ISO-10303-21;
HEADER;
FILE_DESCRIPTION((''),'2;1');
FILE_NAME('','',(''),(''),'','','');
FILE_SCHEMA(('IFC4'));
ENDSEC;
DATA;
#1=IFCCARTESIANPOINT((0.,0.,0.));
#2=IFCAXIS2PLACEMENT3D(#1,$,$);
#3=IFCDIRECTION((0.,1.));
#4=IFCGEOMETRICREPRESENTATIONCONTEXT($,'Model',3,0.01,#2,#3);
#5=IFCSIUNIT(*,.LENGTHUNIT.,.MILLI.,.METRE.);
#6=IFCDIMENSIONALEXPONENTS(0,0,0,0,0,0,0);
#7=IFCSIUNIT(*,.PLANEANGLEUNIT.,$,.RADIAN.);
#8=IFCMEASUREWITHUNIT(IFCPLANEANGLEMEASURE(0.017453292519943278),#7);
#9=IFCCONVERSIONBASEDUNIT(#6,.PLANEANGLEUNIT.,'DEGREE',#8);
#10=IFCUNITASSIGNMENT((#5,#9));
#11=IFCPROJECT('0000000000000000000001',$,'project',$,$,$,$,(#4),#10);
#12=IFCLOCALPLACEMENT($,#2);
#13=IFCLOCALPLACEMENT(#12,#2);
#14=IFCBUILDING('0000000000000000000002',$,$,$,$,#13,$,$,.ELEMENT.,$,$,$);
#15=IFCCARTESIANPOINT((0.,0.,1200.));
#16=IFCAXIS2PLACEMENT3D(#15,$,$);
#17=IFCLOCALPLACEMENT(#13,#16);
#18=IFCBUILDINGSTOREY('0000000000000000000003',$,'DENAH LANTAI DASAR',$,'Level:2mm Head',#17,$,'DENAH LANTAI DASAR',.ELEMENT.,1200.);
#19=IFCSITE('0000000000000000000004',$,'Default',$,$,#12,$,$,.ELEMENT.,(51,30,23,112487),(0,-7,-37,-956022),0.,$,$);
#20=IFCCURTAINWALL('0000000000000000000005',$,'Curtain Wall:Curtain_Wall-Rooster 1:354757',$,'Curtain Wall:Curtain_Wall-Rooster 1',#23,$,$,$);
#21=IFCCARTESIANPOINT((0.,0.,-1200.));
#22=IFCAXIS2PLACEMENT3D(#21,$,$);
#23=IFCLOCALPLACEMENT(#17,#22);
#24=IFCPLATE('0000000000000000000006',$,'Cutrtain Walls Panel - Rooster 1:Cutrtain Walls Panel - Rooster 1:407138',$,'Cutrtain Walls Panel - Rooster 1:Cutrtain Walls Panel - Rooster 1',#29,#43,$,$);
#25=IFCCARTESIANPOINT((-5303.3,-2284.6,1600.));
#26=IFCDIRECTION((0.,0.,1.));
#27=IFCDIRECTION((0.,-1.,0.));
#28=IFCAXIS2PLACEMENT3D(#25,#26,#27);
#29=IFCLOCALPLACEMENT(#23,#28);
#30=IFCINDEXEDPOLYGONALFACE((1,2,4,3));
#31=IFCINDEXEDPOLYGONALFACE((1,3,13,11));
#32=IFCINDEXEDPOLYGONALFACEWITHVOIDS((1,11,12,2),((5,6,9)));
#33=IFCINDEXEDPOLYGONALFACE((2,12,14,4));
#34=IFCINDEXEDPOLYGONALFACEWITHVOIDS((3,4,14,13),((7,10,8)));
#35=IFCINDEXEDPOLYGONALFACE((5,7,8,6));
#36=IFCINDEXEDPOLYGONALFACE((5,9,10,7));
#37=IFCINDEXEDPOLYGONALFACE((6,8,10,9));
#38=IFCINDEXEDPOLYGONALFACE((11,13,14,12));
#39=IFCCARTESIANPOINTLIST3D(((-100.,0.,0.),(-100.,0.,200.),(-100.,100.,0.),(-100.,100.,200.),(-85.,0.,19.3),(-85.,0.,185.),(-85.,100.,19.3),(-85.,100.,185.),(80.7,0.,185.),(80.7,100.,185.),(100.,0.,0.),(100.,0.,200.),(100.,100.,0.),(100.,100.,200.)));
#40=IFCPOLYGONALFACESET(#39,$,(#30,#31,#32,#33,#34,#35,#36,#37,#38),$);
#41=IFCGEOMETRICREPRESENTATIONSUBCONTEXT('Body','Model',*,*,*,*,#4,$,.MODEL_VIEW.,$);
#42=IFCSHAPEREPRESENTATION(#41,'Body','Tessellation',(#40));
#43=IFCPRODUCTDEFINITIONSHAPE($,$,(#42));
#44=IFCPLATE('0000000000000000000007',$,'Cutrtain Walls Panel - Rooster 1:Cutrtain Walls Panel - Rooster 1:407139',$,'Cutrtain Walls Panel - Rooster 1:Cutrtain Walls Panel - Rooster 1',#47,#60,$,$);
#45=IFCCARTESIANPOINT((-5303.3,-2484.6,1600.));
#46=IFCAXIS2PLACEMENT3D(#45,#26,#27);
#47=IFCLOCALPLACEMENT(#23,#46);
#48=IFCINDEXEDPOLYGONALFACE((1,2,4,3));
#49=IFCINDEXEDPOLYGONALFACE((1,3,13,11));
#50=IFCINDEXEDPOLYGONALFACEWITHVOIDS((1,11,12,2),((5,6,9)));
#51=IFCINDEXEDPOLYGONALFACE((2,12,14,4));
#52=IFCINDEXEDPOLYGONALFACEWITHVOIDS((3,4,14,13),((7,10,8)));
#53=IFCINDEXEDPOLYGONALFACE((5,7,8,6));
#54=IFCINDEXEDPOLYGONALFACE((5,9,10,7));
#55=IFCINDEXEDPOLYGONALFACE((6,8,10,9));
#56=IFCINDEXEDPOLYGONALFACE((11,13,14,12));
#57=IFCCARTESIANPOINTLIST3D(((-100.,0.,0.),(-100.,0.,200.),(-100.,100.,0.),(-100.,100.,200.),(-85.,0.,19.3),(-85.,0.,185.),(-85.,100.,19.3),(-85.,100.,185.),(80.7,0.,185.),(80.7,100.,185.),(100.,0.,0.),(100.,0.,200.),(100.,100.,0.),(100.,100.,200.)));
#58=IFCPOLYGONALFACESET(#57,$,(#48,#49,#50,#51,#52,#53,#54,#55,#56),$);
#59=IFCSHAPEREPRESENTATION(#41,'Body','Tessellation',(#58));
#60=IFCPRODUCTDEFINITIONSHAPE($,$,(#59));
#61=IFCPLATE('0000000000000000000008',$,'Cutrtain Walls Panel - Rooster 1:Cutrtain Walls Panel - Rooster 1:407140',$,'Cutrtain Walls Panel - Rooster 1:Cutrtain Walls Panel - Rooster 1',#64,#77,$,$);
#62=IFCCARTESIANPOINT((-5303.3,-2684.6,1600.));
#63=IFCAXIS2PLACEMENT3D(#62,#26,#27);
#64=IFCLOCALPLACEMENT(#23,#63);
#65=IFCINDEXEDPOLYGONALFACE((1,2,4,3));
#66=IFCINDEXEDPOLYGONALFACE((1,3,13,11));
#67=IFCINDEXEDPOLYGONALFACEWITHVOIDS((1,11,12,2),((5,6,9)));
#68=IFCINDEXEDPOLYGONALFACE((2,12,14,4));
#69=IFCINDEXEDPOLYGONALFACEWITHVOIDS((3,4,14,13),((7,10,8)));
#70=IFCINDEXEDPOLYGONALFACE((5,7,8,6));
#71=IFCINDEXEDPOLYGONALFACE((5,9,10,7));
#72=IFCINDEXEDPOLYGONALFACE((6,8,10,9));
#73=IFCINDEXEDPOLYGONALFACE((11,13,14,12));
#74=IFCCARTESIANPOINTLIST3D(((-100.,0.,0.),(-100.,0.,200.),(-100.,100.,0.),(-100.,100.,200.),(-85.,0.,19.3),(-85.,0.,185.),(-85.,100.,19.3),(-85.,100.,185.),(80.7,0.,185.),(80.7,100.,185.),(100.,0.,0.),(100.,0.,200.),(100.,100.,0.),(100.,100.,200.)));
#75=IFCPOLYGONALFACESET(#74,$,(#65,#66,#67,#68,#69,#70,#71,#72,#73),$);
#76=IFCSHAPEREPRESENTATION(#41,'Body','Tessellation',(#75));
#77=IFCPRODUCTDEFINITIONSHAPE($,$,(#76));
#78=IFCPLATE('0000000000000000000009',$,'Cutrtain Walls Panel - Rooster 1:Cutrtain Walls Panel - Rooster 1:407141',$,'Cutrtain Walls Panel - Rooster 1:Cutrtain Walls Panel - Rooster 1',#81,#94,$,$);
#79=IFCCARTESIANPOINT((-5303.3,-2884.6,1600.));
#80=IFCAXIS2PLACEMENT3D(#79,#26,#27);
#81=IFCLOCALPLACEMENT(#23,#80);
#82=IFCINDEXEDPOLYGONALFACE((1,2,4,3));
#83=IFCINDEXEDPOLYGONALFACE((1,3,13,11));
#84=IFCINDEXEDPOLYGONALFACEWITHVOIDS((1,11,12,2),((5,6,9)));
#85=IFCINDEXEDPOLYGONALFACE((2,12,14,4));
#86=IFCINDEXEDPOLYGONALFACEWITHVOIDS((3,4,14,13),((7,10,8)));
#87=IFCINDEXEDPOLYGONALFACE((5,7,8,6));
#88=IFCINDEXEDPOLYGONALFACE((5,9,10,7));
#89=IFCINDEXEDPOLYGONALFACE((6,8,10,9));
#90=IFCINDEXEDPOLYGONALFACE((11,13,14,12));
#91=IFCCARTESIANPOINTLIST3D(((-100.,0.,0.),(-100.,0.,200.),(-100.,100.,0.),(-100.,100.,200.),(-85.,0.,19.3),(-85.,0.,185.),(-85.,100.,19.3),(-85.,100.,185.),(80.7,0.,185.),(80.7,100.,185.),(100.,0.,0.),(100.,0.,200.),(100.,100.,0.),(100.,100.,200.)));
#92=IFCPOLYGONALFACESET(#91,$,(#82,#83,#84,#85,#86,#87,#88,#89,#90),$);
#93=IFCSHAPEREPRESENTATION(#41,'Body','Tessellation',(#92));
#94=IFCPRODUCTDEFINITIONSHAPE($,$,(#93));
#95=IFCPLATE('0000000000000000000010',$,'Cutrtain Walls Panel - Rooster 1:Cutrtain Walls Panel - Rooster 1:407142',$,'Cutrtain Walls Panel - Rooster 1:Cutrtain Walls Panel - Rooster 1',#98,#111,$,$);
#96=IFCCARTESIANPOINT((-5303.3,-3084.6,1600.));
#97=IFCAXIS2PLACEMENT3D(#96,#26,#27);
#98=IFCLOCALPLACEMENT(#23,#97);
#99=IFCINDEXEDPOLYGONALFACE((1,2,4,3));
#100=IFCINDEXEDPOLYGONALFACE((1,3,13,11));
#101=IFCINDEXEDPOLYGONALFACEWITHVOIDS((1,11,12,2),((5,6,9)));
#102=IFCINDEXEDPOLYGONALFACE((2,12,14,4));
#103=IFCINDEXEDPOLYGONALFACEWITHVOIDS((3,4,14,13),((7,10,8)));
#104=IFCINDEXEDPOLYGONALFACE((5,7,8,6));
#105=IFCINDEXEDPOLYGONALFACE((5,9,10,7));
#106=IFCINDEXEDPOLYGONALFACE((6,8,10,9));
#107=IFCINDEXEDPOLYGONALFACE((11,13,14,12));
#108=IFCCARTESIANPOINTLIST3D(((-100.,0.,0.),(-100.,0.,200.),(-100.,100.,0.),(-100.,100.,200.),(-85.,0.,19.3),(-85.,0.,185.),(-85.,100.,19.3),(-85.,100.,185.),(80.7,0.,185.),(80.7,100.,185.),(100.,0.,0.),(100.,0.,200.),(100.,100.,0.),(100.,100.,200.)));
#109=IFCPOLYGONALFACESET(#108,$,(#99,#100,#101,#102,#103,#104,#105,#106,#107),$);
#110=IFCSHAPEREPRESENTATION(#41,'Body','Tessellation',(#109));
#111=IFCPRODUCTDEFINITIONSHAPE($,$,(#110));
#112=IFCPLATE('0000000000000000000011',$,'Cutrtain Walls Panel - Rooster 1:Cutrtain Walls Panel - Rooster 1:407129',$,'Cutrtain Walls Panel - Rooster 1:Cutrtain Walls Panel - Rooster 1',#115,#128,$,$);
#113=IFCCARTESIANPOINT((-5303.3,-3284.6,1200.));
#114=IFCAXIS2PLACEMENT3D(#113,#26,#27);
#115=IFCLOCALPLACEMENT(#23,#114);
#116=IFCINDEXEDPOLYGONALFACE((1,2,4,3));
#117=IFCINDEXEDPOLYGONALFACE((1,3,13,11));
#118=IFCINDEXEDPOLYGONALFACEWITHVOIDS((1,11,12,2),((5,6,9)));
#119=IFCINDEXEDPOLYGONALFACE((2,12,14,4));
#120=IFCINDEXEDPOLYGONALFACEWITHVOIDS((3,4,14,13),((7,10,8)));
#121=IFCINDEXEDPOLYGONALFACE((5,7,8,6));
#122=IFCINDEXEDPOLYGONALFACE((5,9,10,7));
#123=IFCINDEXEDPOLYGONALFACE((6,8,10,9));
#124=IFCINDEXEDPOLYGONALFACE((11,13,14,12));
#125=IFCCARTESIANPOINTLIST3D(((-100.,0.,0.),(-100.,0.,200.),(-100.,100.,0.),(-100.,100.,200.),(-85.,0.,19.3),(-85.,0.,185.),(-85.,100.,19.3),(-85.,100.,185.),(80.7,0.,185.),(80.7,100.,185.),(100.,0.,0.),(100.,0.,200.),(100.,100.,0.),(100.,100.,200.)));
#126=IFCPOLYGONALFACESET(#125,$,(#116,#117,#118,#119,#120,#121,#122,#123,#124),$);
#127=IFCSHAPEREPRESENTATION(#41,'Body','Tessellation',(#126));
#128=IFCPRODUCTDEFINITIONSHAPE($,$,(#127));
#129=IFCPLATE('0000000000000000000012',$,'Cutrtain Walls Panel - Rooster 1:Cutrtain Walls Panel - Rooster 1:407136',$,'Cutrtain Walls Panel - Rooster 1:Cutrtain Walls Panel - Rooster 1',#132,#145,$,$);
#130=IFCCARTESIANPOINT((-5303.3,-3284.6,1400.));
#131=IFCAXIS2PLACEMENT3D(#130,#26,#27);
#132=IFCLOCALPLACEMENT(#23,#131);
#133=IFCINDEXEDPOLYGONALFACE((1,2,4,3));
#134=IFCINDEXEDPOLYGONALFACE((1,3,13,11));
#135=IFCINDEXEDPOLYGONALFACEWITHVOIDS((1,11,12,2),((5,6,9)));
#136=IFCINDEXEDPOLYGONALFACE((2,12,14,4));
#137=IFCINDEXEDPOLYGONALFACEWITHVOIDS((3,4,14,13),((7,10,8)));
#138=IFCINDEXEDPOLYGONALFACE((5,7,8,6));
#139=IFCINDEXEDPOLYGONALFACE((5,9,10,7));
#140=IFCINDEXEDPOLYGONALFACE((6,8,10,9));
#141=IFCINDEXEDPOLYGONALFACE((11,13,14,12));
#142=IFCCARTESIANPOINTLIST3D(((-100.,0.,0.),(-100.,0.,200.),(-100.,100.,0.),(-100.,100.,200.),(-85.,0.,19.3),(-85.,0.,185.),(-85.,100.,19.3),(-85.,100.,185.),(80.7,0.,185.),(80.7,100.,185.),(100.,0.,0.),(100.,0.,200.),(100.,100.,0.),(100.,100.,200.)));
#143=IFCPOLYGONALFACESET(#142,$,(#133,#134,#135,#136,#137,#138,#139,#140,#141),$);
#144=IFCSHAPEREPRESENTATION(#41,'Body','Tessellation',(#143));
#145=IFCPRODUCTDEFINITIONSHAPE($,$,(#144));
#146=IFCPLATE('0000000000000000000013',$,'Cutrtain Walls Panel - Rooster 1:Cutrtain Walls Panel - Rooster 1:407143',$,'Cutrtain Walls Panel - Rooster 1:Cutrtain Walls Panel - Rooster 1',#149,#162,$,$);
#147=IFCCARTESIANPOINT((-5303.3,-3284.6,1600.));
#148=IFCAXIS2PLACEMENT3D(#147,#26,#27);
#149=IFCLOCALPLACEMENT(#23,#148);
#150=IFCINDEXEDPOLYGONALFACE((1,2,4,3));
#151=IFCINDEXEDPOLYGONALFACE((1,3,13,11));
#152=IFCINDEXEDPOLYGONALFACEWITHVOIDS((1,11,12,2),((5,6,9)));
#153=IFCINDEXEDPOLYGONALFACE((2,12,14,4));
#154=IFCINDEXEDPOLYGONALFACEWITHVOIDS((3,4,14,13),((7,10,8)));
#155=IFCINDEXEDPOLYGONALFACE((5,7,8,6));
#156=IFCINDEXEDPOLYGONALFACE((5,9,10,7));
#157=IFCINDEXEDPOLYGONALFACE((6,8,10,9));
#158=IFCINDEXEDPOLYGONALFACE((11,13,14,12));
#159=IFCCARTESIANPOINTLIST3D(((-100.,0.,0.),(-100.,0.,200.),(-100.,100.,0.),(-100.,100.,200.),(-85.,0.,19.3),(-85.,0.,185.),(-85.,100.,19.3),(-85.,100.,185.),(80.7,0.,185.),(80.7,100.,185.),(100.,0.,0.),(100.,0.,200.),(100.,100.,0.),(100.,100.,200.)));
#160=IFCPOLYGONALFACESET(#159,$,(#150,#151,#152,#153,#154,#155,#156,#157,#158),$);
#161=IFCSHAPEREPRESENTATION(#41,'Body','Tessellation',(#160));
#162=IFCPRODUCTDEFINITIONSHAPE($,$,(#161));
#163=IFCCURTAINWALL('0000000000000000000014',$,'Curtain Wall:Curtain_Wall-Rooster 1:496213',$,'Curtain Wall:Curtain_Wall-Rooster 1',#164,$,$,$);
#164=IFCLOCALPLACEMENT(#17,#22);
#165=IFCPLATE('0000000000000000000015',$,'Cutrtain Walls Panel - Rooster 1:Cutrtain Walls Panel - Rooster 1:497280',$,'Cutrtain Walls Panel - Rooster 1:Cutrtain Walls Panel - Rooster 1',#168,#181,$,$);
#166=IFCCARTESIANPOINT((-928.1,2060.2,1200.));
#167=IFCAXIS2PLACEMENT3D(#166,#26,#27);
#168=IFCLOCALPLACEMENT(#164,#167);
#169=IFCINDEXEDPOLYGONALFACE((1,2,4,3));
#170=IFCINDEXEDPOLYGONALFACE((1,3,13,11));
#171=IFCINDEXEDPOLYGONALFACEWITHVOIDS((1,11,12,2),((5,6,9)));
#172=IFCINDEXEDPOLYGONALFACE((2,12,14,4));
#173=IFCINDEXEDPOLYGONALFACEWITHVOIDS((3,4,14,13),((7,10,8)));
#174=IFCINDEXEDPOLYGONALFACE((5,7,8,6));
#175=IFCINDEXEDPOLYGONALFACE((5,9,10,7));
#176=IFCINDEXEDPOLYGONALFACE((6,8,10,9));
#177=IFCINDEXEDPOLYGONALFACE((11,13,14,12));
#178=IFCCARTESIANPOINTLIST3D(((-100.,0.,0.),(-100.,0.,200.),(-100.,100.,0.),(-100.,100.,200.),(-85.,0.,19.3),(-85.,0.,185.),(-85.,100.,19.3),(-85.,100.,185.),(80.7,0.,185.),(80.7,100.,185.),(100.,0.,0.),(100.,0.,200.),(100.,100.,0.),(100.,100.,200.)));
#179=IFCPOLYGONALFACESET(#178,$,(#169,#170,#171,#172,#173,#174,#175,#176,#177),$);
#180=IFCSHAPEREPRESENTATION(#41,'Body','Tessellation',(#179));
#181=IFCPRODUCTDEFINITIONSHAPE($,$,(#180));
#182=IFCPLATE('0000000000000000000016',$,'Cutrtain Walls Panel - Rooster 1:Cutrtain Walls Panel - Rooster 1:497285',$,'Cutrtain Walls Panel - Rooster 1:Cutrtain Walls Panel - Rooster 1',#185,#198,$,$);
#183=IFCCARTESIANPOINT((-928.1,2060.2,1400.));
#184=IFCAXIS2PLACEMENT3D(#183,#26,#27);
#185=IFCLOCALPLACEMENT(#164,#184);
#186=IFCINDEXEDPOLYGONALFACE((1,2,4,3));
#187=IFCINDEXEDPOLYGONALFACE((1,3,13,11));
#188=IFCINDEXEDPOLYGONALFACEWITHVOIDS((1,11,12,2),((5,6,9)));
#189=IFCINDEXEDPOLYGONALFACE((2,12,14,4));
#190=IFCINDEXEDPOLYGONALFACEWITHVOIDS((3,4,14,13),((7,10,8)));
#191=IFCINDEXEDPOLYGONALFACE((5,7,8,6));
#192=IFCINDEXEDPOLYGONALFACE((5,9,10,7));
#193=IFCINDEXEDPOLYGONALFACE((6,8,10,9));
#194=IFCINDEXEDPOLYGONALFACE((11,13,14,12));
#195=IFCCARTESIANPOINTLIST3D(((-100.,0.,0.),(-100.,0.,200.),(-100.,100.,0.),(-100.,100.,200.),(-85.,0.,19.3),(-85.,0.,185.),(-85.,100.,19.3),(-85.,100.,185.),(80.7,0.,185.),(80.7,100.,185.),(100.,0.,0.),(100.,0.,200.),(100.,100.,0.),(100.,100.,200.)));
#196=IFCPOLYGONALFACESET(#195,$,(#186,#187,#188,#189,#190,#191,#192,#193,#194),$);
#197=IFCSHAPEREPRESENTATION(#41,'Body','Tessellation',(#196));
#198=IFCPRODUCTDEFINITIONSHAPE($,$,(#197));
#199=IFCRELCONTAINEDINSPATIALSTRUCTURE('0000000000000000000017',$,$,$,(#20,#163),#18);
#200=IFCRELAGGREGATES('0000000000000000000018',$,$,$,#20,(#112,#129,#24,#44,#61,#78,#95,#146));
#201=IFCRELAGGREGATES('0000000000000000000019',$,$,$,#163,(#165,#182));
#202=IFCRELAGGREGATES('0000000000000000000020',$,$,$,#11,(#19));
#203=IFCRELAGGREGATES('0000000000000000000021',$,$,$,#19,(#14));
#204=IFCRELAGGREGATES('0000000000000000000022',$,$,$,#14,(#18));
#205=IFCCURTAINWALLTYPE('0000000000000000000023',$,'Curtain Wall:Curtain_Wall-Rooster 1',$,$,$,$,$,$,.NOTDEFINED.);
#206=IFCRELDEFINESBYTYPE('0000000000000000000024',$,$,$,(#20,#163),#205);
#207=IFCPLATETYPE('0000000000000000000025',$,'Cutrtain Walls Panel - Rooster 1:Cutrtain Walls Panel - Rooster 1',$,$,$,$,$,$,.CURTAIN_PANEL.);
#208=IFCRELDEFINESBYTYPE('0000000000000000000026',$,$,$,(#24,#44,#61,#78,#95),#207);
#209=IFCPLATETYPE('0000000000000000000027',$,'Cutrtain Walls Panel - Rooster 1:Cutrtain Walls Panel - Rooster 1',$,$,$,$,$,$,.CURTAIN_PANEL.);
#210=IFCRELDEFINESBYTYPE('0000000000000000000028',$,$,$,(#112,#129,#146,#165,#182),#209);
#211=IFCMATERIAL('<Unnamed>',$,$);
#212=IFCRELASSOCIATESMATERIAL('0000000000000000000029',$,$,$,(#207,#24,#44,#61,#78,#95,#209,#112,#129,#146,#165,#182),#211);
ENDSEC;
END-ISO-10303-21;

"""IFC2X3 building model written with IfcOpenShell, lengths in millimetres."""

from ifc_helpers import new_model, entity, si_unit, converted_unit, direction, frame, origin, place, context, subcontext, project, spatial, polyline, outline, extrude, source, transform, mapped, material, type_object, type_shapes, element, aggregate, save


model = new_model("IFC2X3")

# Units and contexts
model_context = context("Model", 3, precision=0.01, world=origin(), true_north=direction((0.0, 1.0)))
body_context = subcontext(model_context, "Body", "Model", "MODEL_VIEW")
ifc_project = project(units=[si_unit("LENGTHUNIT", "METRE", prefix="MILLI"), converted_unit("PLANEANGLEUNIT", "DEGREE", entity("IfcPlaneAngleMeasure", 0.017453292519943278), si_unit("PLANEANGLEUNIT", "RADIAN"), dimensions=[0, 0, 0, 0, 0, 0, 0])], contexts=[model_context])

# Site, building, storey
site_placement = place(None, origin())
site = spatial("IfcSite", under=ifc_project, at=site_placement, Name="Default", CompositionType="ELEMENT", RefLatitude=(51, 30, 23, 112487), RefLongitude=(0, -7, -37, -956022), RefElevation=0.0)
building_placement = place(site_placement, origin())
building = spatial("IfcBuilding", under=site, at=building_placement, CompositionType="ELEMENT")
storey_placement = place(building_placement, frame((0.0, 0.0, 1200.0)))
storey = spatial("IfcBuildingStorey", under=building, at=storey_placement, Name="DENAH LANTAI DASAR", ObjectType="Level:2mm Head", LongName="DENAH LANTAI DASAR", CompositionType="ELEMENT", Elevation=1200.0)

# Curtain walls, plates
curtain_wall_type = type_object("IfcCurtainWallType", Name="Curtain Wall:Curtain_Wall-Rooster 1", PredefinedType="NOTDEFINED")
curtain_wall_1_placement = place(storey_placement, frame((0.0, 0.0, -1200.0)))
curtain_wall_1 = element("IfcCurtainWall", 1, at=curtain_wall_1_placement, inside=storey, type_object=curtain_wall_type, Name="Curtain Wall:Curtain_Wall-Rooster 1:354757", ObjectType="Curtain Wall:Curtain_Wall-Rooster 1")
ifc_material_1 = material(Name="<Unnamed>")
plate_type_1 = type_object("IfcPlateType", Name="Cutrtain Walls Panel - Rooster 1:Cutrtain Walls Panel - Rooster 1", PredefinedType="CURTAIN_PANEL", material=ifc_material_1)
shared_shape_1 = source(origin(), body_context, "Body", "SweptSolid", [
    extrude(outline(polyline([(-100.0, -100.0), (100.0, -100.0), (100.0, 100.0), (-100.0, 100.0), (-100.0, -100.0)]), holes=[polyline([(80.7, 85.0), (-85.0, -80.7), (-85.0, 85.0), (80.7, 85.0)])]), frame((0.0, 0.0, 100.0), z_axis=(0.0, 1.0, 0.0), x_axis=(0.0, 0.0, -1.0)), (0.0, 0.0, 1.0), 100.0),
])
type_shapes(plate_type_1, [shared_shape_1])
plate_1_placement = place(curtain_wall_1_placement, frame((-5303.3, -2284.6, 1600.0), z_axis=(0.0, 0.0, 1.0), x_axis=(0.0, -1.0, 0.0)))
plate_1 = element("IfcPlate", 2, at=plate_1_placement, type_object=plate_type_1, material=ifc_material_1, Name="Cutrtain Walls Panel - Rooster 1:Cutrtain Walls Panel - Rooster 1:407138", ObjectType="Cutrtain Walls Panel - Rooster 1:Cutrtain Walls Panel - Rooster 1", context=body_context, shape_type="MappedRepresentation", body=[
    mapped(shared_shape_1, transform((0.0, 0.0, 0.0), scale=1.0)),
])
plate_2_placement = place(curtain_wall_1_placement, frame((-5303.3, -2484.6, 1600.0), z_axis=(0.0, 0.0, 1.0), x_axis=(0.0, -1.0, 0.0)))
plate_2 = element("IfcPlate", 3, at=plate_2_placement, type_object=plate_type_1, material=ifc_material_1, Name="Cutrtain Walls Panel - Rooster 1:Cutrtain Walls Panel - Rooster 1:407139", ObjectType="Cutrtain Walls Panel - Rooster 1:Cutrtain Walls Panel - Rooster 1", context=body_context, shape_type="MappedRepresentation", body=[
    mapped(shared_shape_1, transform((0.0, 0.0, 0.0), scale=1.0)),
])
plate_3_placement = place(curtain_wall_1_placement, frame((-5303.3, -2684.6, 1600.0), z_axis=(0.0, 0.0, 1.0), x_axis=(0.0, -1.0, 0.0)))
plate_3 = element("IfcPlate", 4, at=plate_3_placement, type_object=plate_type_1, material=ifc_material_1, Name="Cutrtain Walls Panel - Rooster 1:Cutrtain Walls Panel - Rooster 1:407140", ObjectType="Cutrtain Walls Panel - Rooster 1:Cutrtain Walls Panel - Rooster 1", context=body_context, shape_type="MappedRepresentation", body=[
    mapped(shared_shape_1, transform((0.0, 0.0, 0.0), scale=1.0)),
])
plate_4_placement = place(curtain_wall_1_placement, frame((-5303.3, -2884.6, 1600.0), z_axis=(0.0, 0.0, 1.0), x_axis=(0.0, -1.0, 0.0)))
plate_4 = element("IfcPlate", 5, at=plate_4_placement, type_object=plate_type_1, material=ifc_material_1, Name="Cutrtain Walls Panel - Rooster 1:Cutrtain Walls Panel - Rooster 1:407141", ObjectType="Cutrtain Walls Panel - Rooster 1:Cutrtain Walls Panel - Rooster 1", context=body_context, shape_type="MappedRepresentation", body=[
    mapped(shared_shape_1, transform((0.0, 0.0, 0.0), scale=1.0)),
])
plate_5_placement = place(curtain_wall_1_placement, frame((-5303.3, -3084.6, 1600.0), z_axis=(0.0, 0.0, 1.0), x_axis=(0.0, -1.0, 0.0)))
plate_5 = element("IfcPlate", 6, at=plate_5_placement, type_object=plate_type_1, material=ifc_material_1, Name="Cutrtain Walls Panel - Rooster 1:Cutrtain Walls Panel - Rooster 1:407142", ObjectType="Cutrtain Walls Panel - Rooster 1:Cutrtain Walls Panel - Rooster 1", context=body_context, shape_type="MappedRepresentation", body=[
    mapped(shared_shape_1, transform((0.0, 0.0, 0.0), scale=1.0)),
])
plate_type_2 = type_object("IfcPlateType", Name="Cutrtain Walls Panel - Rooster 1:Cutrtain Walls Panel - Rooster 1", PredefinedType="CURTAIN_PANEL", material=ifc_material_1)
shared_shape_2 = source(origin(), body_context, "Body", "SweptSolid", [
    extrude(outline(polyline([(-100.0, -100.0), (100.0, -100.0), (100.0, 100.0), (-100.0, 100.0), (-100.0, -100.0)]), holes=[polyline([(80.7, 85.0), (-85.0, -80.7), (-85.0, 85.0), (80.7, 85.0)])]), frame((0.0, 0.0, 100.0), z_axis=(0.0, 1.0, 0.0), x_axis=(0.0, 0.0, -1.0)), (0.0, 0.0, 1.0), 100.0),
])
type_shapes(plate_type_2, [shared_shape_2])
plate_6_placement = place(curtain_wall_1_placement, frame((-5303.3, -3284.6, 1200.0), z_axis=(0.0, 0.0, 1.0), x_axis=(0.0, -1.0, 0.0)))
plate_6 = element("IfcPlate", 7, at=plate_6_placement, type_object=plate_type_2, material=ifc_material_1, Name="Cutrtain Walls Panel - Rooster 1:Cutrtain Walls Panel - Rooster 1:407129", ObjectType="Cutrtain Walls Panel - Rooster 1:Cutrtain Walls Panel - Rooster 1", context=body_context, shape_type="MappedRepresentation", body=[
    mapped(shared_shape_2, transform((0.0, 0.0, 0.0), scale=1.0)),
])
plate_7_placement = place(curtain_wall_1_placement, frame((-5303.3, -3284.6, 1400.0), z_axis=(0.0, 0.0, 1.0), x_axis=(0.0, -1.0, 0.0)))
plate_7 = element("IfcPlate", 8, at=plate_7_placement, type_object=plate_type_2, material=ifc_material_1, Name="Cutrtain Walls Panel - Rooster 1:Cutrtain Walls Panel - Rooster 1:407136", ObjectType="Cutrtain Walls Panel - Rooster 1:Cutrtain Walls Panel - Rooster 1", context=body_context, shape_type="MappedRepresentation", body=[
    mapped(shared_shape_2, transform((0.0, 0.0, 0.0), scale=1.0)),
])
plate_8_placement = place(curtain_wall_1_placement, frame((-5303.3, -3284.6, 1600.0), z_axis=(0.0, 0.0, 1.0), x_axis=(0.0, -1.0, 0.0)))
plate_8 = element("IfcPlate", 9, at=plate_8_placement, type_object=plate_type_2, material=ifc_material_1, Name="Cutrtain Walls Panel - Rooster 1:Cutrtain Walls Panel - Rooster 1:407143", ObjectType="Cutrtain Walls Panel - Rooster 1:Cutrtain Walls Panel - Rooster 1", context=body_context, shape_type="MappedRepresentation", body=[
    mapped(shared_shape_2, transform((0.0, 0.0, 0.0), scale=1.0)),
])
aggregate(curtain_wall_1, [plate_6, plate_7, plate_1, plate_2, plate_3, plate_4, plate_5, plate_8])
curtain_wall_2_placement = place(storey_placement, frame((0.0, 0.0, -1200.0)))
curtain_wall_2 = element("IfcCurtainWall", 10, at=curtain_wall_2_placement, inside=storey, type_object=curtain_wall_type, Name="Curtain Wall:Curtain_Wall-Rooster 1:496213", ObjectType="Curtain Wall:Curtain_Wall-Rooster 1")
plate_9_placement = place(curtain_wall_2_placement, frame((-928.1, 2060.2, 1200.0), z_axis=(0.0, 0.0, 1.0), x_axis=(0.0, -1.0, 0.0)))
plate_9 = element("IfcPlate", 11, at=plate_9_placement, type_object=plate_type_2, material=ifc_material_1, Name="Cutrtain Walls Panel - Rooster 1:Cutrtain Walls Panel - Rooster 1:497280", ObjectType="Cutrtain Walls Panel - Rooster 1:Cutrtain Walls Panel - Rooster 1", context=body_context, shape_type="MappedRepresentation", body=[
    mapped(shared_shape_2, transform((0.0, 0.0, 0.0), scale=1.0)),
])
plate_10_placement = place(curtain_wall_2_placement, frame((-928.1, 2060.2, 1400.0), z_axis=(0.0, 0.0, 1.0), x_axis=(0.0, -1.0, 0.0)))
plate_10 = element("IfcPlate", 12, at=plate_10_placement, type_object=plate_type_2, material=ifc_material_1, Name="Cutrtain Walls Panel - Rooster 1:Cutrtain Walls Panel - Rooster 1:497285", ObjectType="Cutrtain Walls Panel - Rooster 1:Cutrtain Walls Panel - Rooster 1", context=body_context, shape_type="MappedRepresentation", body=[
    mapped(shared_shape_2, transform((0.0, 0.0, 0.0), scale=1.0)),
])
aggregate(curtain_wall_2, [plate_9, plate_10])

save(model, "model.ifc")
